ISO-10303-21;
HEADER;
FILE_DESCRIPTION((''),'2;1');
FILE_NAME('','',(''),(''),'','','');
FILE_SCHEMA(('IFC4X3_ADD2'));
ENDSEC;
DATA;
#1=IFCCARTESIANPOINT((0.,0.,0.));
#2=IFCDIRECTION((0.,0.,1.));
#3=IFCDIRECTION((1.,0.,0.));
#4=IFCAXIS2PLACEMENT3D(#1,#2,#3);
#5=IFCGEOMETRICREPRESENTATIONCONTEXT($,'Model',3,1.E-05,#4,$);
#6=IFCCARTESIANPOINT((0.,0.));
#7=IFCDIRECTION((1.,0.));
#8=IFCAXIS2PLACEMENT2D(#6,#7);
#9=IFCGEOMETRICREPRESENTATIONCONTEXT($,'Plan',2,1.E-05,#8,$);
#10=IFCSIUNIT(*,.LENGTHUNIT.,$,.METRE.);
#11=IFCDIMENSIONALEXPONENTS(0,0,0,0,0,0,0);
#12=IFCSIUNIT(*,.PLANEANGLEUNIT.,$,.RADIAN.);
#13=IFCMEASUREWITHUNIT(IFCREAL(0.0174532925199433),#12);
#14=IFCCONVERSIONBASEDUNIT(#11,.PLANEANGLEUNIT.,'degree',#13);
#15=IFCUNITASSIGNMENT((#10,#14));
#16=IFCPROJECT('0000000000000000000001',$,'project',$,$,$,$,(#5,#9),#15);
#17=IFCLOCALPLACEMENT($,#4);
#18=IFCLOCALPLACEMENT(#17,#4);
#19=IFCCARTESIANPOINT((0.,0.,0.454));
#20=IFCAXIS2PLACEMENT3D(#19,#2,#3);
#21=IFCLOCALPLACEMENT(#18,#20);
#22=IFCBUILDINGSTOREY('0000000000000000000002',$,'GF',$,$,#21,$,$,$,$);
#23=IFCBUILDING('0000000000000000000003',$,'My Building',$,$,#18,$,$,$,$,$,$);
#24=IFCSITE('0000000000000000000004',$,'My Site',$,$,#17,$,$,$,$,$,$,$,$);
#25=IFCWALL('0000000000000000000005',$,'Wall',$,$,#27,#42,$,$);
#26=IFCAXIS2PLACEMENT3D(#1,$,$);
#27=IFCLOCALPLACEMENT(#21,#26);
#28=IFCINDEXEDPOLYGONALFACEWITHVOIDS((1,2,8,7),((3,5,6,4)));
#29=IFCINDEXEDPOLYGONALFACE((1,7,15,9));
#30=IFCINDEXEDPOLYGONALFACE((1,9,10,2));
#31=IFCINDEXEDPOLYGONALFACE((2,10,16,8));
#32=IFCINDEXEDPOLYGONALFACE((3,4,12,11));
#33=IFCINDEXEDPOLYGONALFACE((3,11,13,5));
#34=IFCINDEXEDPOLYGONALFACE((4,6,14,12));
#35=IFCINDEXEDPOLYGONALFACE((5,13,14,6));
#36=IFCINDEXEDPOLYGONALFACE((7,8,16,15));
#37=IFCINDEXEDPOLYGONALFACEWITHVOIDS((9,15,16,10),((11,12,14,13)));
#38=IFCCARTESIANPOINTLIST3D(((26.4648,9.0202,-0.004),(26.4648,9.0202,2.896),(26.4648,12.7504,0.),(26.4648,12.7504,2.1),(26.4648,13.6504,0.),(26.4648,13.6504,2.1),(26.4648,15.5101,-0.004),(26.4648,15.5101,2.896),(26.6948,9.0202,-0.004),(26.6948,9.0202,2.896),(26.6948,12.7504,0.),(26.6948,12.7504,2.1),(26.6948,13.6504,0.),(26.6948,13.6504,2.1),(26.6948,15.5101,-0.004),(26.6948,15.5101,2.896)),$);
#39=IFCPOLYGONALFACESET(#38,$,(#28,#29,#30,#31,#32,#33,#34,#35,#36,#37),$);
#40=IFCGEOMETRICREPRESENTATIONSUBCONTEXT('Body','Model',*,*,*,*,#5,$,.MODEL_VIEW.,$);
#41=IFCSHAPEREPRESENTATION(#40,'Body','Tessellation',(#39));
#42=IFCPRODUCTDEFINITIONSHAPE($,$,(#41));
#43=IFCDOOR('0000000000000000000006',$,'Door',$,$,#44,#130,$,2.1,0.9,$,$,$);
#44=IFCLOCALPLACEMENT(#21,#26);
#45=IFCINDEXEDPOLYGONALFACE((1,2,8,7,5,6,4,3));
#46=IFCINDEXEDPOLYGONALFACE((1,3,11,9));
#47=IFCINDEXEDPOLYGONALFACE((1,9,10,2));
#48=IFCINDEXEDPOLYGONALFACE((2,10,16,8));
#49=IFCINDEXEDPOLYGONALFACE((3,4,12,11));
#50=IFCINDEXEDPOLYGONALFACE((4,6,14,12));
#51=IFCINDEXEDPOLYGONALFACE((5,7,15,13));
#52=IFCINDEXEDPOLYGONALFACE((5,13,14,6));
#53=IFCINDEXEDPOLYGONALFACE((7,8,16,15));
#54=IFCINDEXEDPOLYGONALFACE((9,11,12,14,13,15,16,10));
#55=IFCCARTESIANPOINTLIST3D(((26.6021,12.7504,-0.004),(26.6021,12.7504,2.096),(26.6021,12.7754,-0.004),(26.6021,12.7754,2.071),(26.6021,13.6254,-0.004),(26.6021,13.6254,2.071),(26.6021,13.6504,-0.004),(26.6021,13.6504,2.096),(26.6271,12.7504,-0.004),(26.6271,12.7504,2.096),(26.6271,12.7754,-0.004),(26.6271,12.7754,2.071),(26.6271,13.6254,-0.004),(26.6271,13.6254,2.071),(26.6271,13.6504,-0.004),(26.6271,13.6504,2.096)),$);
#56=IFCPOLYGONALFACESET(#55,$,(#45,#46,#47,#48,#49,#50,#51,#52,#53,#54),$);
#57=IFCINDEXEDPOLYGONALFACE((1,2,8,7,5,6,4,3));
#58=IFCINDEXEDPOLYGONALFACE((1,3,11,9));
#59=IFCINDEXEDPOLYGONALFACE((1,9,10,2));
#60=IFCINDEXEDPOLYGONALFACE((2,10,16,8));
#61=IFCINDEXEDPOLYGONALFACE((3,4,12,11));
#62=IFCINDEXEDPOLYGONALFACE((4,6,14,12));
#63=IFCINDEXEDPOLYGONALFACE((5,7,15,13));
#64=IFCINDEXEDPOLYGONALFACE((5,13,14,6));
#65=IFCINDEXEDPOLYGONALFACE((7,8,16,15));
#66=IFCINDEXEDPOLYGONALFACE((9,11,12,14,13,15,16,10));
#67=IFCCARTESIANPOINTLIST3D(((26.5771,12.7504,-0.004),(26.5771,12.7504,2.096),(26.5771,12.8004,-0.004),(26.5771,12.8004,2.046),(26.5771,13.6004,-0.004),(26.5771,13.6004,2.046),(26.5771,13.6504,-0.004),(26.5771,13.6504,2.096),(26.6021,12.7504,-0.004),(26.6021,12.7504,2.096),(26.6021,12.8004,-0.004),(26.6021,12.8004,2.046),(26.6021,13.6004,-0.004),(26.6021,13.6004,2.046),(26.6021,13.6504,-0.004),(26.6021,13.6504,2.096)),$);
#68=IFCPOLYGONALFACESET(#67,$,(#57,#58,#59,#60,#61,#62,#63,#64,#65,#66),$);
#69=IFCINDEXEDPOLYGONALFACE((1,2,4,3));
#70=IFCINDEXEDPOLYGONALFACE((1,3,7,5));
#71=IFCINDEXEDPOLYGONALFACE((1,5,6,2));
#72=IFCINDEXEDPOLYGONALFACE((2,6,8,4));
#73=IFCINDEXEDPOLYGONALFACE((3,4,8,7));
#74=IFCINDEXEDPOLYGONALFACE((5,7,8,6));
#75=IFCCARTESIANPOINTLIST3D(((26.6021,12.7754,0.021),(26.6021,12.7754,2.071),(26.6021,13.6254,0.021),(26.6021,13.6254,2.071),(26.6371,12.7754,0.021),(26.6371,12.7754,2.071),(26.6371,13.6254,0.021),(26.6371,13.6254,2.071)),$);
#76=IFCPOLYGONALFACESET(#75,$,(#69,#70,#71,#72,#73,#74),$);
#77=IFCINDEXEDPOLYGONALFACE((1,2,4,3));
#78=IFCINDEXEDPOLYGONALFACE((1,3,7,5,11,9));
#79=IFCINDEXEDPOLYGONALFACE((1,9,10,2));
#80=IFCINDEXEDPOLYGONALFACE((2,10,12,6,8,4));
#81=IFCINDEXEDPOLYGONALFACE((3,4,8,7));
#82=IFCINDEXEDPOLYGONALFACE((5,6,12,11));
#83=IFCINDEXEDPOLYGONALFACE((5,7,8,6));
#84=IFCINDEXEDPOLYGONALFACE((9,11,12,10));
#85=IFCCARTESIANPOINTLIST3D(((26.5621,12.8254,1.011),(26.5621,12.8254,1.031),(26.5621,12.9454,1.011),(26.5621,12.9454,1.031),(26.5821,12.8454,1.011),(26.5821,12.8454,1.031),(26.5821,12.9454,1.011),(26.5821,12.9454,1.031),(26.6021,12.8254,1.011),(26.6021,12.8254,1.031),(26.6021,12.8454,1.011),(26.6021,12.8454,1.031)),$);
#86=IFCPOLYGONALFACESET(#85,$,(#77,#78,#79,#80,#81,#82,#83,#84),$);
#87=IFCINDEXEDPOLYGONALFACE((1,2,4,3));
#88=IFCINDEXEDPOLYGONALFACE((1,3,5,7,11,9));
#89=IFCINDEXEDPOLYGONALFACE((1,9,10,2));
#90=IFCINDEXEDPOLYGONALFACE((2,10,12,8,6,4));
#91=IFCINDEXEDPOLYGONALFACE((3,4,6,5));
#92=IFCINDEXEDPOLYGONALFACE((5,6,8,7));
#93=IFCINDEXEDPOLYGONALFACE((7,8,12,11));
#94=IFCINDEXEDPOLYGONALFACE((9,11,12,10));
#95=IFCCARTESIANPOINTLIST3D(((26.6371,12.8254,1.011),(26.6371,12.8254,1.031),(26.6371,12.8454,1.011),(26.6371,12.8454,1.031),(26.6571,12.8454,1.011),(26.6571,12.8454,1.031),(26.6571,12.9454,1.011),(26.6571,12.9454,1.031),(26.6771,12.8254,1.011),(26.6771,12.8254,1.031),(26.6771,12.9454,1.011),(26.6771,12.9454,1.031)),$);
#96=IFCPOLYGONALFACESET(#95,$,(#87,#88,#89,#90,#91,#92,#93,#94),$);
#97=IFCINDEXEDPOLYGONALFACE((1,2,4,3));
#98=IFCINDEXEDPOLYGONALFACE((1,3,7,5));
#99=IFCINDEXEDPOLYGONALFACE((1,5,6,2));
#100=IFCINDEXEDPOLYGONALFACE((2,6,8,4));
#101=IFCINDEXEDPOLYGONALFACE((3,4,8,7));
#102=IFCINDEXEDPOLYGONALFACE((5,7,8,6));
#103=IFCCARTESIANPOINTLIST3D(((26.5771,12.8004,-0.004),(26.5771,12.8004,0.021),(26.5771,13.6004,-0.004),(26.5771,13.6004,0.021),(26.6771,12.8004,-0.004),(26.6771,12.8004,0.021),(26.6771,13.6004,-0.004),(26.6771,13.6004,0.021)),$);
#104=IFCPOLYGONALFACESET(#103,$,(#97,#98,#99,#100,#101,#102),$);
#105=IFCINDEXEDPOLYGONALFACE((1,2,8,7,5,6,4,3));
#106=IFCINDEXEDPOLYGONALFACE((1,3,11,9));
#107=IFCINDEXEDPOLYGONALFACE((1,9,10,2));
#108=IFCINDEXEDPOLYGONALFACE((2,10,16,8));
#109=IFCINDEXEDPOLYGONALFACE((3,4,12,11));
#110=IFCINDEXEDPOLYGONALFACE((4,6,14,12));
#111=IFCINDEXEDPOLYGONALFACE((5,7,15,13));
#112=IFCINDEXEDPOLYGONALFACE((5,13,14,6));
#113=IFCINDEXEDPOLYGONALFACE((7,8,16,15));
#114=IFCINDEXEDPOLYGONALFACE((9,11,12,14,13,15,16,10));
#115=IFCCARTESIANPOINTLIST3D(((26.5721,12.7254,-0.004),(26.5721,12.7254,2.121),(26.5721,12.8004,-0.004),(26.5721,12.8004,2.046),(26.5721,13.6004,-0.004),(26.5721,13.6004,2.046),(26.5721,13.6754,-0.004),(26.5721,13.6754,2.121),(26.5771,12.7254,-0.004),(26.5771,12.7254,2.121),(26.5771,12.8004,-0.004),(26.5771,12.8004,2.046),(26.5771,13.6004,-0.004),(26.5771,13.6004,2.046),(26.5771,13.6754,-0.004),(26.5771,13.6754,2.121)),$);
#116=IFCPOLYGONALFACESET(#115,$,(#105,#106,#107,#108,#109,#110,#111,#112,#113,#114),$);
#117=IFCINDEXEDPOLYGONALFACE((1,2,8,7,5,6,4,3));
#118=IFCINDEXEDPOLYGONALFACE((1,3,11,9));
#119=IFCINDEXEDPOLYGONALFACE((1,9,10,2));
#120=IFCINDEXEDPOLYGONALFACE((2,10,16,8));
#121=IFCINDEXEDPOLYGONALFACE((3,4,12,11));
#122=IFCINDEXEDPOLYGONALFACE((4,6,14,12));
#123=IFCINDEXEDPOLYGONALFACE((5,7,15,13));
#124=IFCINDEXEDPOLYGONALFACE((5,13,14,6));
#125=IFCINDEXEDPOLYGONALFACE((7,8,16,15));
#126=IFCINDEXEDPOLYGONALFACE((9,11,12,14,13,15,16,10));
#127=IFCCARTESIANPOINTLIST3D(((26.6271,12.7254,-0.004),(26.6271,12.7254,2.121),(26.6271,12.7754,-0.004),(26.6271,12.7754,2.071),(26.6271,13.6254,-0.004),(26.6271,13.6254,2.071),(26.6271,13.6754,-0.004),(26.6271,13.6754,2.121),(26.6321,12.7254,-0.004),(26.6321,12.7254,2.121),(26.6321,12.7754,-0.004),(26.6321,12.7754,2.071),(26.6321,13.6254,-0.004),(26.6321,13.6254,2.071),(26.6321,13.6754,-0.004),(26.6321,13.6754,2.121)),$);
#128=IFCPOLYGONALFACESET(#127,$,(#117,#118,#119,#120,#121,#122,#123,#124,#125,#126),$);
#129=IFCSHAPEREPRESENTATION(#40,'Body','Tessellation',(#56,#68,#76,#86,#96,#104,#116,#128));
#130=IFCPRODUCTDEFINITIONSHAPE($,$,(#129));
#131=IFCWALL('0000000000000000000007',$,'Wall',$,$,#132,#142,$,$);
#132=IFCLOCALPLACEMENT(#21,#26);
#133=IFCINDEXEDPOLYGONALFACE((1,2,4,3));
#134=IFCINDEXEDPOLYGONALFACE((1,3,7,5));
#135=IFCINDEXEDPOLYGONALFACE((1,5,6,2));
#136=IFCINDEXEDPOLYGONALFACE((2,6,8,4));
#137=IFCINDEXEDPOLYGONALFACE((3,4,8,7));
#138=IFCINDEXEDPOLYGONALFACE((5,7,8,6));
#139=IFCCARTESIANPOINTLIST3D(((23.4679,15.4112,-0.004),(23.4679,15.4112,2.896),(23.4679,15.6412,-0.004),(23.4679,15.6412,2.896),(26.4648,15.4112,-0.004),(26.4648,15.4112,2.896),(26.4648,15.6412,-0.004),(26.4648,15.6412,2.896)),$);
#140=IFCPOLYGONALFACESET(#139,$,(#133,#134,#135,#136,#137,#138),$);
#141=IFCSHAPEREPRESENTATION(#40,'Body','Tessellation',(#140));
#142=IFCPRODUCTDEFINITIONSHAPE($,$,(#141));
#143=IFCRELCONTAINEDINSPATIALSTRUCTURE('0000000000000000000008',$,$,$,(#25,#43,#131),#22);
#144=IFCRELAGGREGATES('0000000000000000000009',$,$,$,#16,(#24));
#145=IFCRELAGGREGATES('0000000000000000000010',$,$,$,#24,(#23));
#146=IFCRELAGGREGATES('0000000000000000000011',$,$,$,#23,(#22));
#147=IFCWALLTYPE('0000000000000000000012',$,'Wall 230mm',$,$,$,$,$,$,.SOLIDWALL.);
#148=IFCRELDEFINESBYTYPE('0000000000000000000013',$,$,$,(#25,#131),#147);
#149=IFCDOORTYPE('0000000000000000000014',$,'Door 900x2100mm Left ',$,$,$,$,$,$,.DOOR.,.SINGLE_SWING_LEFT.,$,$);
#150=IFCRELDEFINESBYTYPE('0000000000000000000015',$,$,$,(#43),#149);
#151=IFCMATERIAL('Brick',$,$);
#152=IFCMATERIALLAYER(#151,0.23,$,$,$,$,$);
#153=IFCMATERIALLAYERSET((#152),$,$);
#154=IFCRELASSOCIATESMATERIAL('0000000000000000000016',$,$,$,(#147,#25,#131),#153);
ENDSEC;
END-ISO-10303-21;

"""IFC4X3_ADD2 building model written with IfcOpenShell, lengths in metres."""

from ifc_helpers import new_model, entity, si_unit, converted_unit, frame, origin_with_axes, origin_2d_with_axis, place, context, subcontext, project, spatial, line, indexed_curve, outline, extrude, shape, source, transform, mapped, material, layer, layer_set, layer_usage, type_object, type_shapes, element, fill, save


model = new_model("IFC4X3_ADD2")

# Units and contexts
model_context = context("Model", 3, precision=1e-05, world=origin_with_axes())
plan_context = context("Plan", 2, precision=1e-05, world=origin_2d_with_axis())
body_context_1 = subcontext(model_context, "Body", "Model", "MODEL_VIEW")
body_context_2 = subcontext(plan_context, "Body", "Plan", "PLAN_VIEW")
ifc_project = project(units=[si_unit("LENGTHUNIT", "METRE"), converted_unit("PLANEANGLEUNIT", "degree", entity("IfcReal", 0.0174532925199433), si_unit("PLANEANGLEUNIT", "RADIAN"), dimensions=[0, 0, 0, 0, 0, 0, 0])], contexts=[model_context, plan_context])

# Site, building, storey
site_placement = place(None, origin_with_axes())
site = spatial("IfcSite", under=ifc_project, at=site_placement, Name="My Site")
building_placement = place(site_placement, origin_with_axes())
building = spatial("IfcBuilding", under=site, at=building_placement, Name="My Building")
storey_placement = place(building_placement, frame((0.0, 0.0, 0.454), z_axis=(0.0, 0.0, 1.0), x_axis=(1.0, 0.0, 0.0)))
storey = spatial("IfcBuildingStorey", under=building, at=storey_placement, Name="GF")

# Shared definitions
ifc_material_1 = material(Name="Brick")

# Shared definitions
shared_shape_1 = source(origin_with_axes(), body_context_1, "Body", "SweptSolid", [
    extrude(outline(indexed_curve([(0.0, 0.0), (0.9, 0.0), (0.9, 2.1), (0.0, 2.1)], segments=[line(1, 2, 3, 4, 1)])), frame((0.0, -0.6, 0.0), z_axis=(0.0, -1.0, 0.0), x_axis=(1.0, 0.0, 0.0)), (0.0, 0.0, -1.0), 1.2),
])
door_type_1 = type_object("IfcDoorType", Name="Door 900x2100mm Left ", OperationType="SINGLE_SWING_LEFT", PredefinedType="DOOR")
shared_shape_2 = source(origin_with_axes(), body_context_1, "Body", "SweptSolid", [
    extrude(outline(indexed_curve([(0.0, 0.0), (0.0, 2.1), (0.9, 2.1), (0.9, 0.0), (0.875, 0.0), (0.875, 2.075), (0.025, 2.075), (0.025, 0.0)], segments=[line(1, 2, 3, 4, 5, 6, 7, 8, 1)])), frame((0.0, 0.025, 0.0), z_axis=(0.0, -1.0, 0.0), x_axis=(1.0, 0.0, 0.0)), (0.0, 0.0, -1.0), 0.025),
    extrude(outline(indexed_curve([(0.0, 0.0), (0.0, 2.1), (0.9, 2.1), (0.9, 0.0), (0.85, 0.0), (0.85, 2.05), (0.05, 2.05), (0.05, 0.0)], segments=[line(1, 2, 3, 4, 5, 6, 7, 8, 1)])), frame((0.0, 0.0, 0.0), z_axis=(0.0, -1.0, 0.0), x_axis=(1.0, 0.0, 0.0)), (0.0, 0.0, -1.0), 0.025),
    extrude(outline(indexed_curve([(0.0, 0.0), (0.85, 0.0), (0.85, 0.035), (0.0, 0.035)], segments=[line(1, 2, 3, 4, 1)])), frame((0.025, 0.025, 0.025), z_axis=(0.0, 0.0, 1.0), x_axis=(1.0, 0.0, 0.0)), (0.0, 0.0, 1.0), 2.05),
    extrude(outline(indexed_curve([(0.0, 0.0), (0.0, -0.04), (-0.12, -0.04), (-0.12, -0.02), (-0.02, -0.02), (-0.02, 0.0)], segments=[line(1, 2, 3, 4, 5, 6, 1)])), frame((0.825, 0.025, 1.015), z_axis=(0.0, 0.0, 1.0), x_axis=(1.0, 0.0, 0.0)), (0.0, 0.0, 1.0), 0.02),
    extrude(outline(indexed_curve([(0.0, 0.0), (0.0, 0.04), (-0.12, 0.04), (-0.12, 0.02), (-0.02, 0.02), (-0.02, 0.0)], segments=[line(1, 2, 3, 4, 5, 6, 1)])), frame((0.825, 0.06, 1.015), z_axis=(0.0, 0.0, 1.0), x_axis=(1.0, 0.0, 0.0)), (0.0, 0.0, 1.0), 0.02),
    extrude(outline(indexed_curve([(0.0, 0.0), (0.8, 0.0), (0.8, 0.1), (0.0, 0.1)], segments=[line(1, 2, 3, 4, 1)])), frame((0.05, 0.0, 0.0), z_axis=(0.0, 0.0, 1.0), x_axis=(1.0, 0.0, 0.0)), (0.0, 0.0, 1.0), 0.025),
    extrude(outline(indexed_curve([(0.0, 0.0), (0.0, 2.125), (0.95, 2.125), (0.95, 0.0), (0.875, 0.0), (0.875, 2.05), (0.075, 2.05), (0.075, 0.0)], segments=[line(1, 2, 3, 4, 5, 6, 7, 8, 1)])), frame((-0.025, -0.005, 0.0), z_axis=(0.0, -1.0, 0.0), x_axis=(1.0, 0.0, 0.0)), (0.0, 0.0, -1.0), 0.005),
    extrude(outline(indexed_curve([(0.0, 0.0), (0.0, 2.125), (0.95, 2.125), (0.95, 0.0), (0.9, 0.0), (0.9, 2.075), (0.05, 2.075), (0.05, 0.0)], segments=[line(1, 2, 3, 4, 5, 6, 7, 8, 1)])), frame((-0.025, 0.05, 0.0), z_axis=(0.0, -1.0, 0.0), x_axis=(1.0, 0.0, 0.0)), (0.0, 0.0, -1.0), 0.005),
])
shared_shape_3 = source(origin_with_axes(), body_context_2, "Body", "Curve2D", [
    entity("IfcIndexedPolyCurve", entity("IfcCartesianPointList2D", [[0.0, 0.0], [0.0, 0.05], [0.025, 0.05], [0.025, 0.025], [0.05, 0.025], [0.05, 0.0]]), [entity("IfcLineIndex", [1, 2, 3, 4, 5, 6, 1])]),
    entity("IfcIndexedPolyCurve", entity("IfcCartesianPointList2D", [[0.9, 0.0], [0.9, 0.05], [0.875, 0.05], [0.875, 0.025], [0.85, 0.025], [0.85, 0.0]]), [entity("IfcLineIndex", [1, 2, 3, 4, 5, 6, 1])]),
    entity("IfcTrimmedCurve", entity("IfcEllipse", entity("IfcAxis2Placement2D", entity("IfcCartesianPoint", [0.06, 0.05]), entity("IfcDirection", [1.0, 0.0])), 0.815, 0.85), [entity("IfcCartesianPoint", [0.875, 0.05])], [entity("IfcCartesianPoint", [0.06, 0.9])], True, "CARTESIAN"),
    entity("IfcIndexedPolyCurve", entity("IfcCartesianPointList2D", [[0.025, 0.05], [0.06, 0.05], [0.06, 0.9], [0.025, 0.9]]), [entity("IfcLineIndex", [1, 2, 3, 4, 1])]),
])
type_shapes(door_type_1, [shared_shape_2, shared_shape_3])

# Shared definitions
ifc_layer_1 = layer(ifc_material_1, 0.23)
ifc_layer_set_1 = layer_set([ifc_layer_1])
wall_type_1 = type_object("IfcWallType", Name="Wall 230mm", PredefinedType="SOLIDWALL", material=ifc_layer_set_1)

# Wall, opening, door
ifc_layer_usage_1 = layer_usage(ifc_layer_set_1, "AXIS2", "POSITIVE", 0.0)
wall_1_placement = place(storey_placement, frame((26.6948, 9.0202, -0.004), z_axis=(0.0, 0.0, 1.0), x_axis=(0.000001, 1.0, 0.0)))
wall_1 = element("IfcWall", 1, at=wall_1_placement, inside=storey, type_object=wall_type_1, material=ifc_layer_usage_1, Name="Wall", context=body_context_1, shape_type="SweptSolid", body=[
    extrude(outline(indexed_curve([(0.0, 0.0), (0.0, 0.23), (6.4899, 0.23), (6.4899, 0.0), (0.0, 0.0)], self_intersect=False)), origin_with_axes(), (0.0, 0.0, 1.0), 2.9),
])
opening_1_placement = place(wall_1_placement, frame((4.6302, 0.1177, 0.004), z_axis=(0.0, 0.0, 1.0), x_axis=(-1.0, 0.0, 0.0)))
opening_1 = element("IfcOpeningElement", 2, at=opening_1_placement, cuts=wall_1, PredefinedType="OPENING", context=body_context_1, shape_type="MappedRepresentation", body=[
    mapped(shared_shape_1, transform((0.0, 0.0, 0.0), x_axis=(1.0, 0.0, 0.0), y_axis=(0.0, 1.0, 0.0), z_axis=(0.0, 0.0, 1.0), scale=1.0)),
])
door_1_placement = place(opening_1_placement, frame((0.0, 0.0, -0.004), z_axis=(0.0, 0.0, 1.0), x_axis=(1.0, 0.0, 0.0)))
door_1 = element("IfcDoor", 3, at=door_1_placement, inside=storey, type_object=door_type_1, Name="Door", OverallHeight=2.1, OverallWidth=0.9, shapes=[
    shape(body_context_1, "Body", "MappedRepresentation", [mapped(shared_shape_2, transform((0.0, 0.0, 0.0), x_axis=(1.0, 0.0, 0.0), y_axis=(0.0, 1.0, 0.0), z_axis=(0.0, 0.0, 1.0), scale=1.0))]),
    shape(body_context_2, "Body", "MappedRepresentation", [mapped(shared_shape_3, transform((0.0, 0.0, 0.0), x_axis=(1.0, 0.0, 0.0), y_axis=(0.0, 1.0, 0.0), z_axis=(0.0, 0.0, 1.0), scale=1.0))]),
])
fill(opening_1, door_1)

# Wall
ifc_layer_usage_2 = layer_usage(ifc_layer_set_1, "AXIS2", "POSITIVE", 0.0)
wall_2_placement = place(storey_placement, frame((26.4648, 15.6412, -0.004), z_axis=(0.0, 0.0, 1.0), x_axis=(-1.0, 0.0, 0.0)))
element("IfcWall", 4, at=wall_2_placement, inside=storey, type_object=wall_type_1, material=ifc_layer_usage_2, Name="Wall", context=body_context_1, shape_type="SweptSolid", body=[
    extrude(outline(indexed_curve([(0.0, 0.0), (0.0, 0.23), (2.9969, 0.23), (2.9969, 0.0), (0.0, 0.0)], self_intersect=False)), origin_with_axes(), (0.0, 0.0, 1.0), 2.9),
])

save(model, "model.ifc")
